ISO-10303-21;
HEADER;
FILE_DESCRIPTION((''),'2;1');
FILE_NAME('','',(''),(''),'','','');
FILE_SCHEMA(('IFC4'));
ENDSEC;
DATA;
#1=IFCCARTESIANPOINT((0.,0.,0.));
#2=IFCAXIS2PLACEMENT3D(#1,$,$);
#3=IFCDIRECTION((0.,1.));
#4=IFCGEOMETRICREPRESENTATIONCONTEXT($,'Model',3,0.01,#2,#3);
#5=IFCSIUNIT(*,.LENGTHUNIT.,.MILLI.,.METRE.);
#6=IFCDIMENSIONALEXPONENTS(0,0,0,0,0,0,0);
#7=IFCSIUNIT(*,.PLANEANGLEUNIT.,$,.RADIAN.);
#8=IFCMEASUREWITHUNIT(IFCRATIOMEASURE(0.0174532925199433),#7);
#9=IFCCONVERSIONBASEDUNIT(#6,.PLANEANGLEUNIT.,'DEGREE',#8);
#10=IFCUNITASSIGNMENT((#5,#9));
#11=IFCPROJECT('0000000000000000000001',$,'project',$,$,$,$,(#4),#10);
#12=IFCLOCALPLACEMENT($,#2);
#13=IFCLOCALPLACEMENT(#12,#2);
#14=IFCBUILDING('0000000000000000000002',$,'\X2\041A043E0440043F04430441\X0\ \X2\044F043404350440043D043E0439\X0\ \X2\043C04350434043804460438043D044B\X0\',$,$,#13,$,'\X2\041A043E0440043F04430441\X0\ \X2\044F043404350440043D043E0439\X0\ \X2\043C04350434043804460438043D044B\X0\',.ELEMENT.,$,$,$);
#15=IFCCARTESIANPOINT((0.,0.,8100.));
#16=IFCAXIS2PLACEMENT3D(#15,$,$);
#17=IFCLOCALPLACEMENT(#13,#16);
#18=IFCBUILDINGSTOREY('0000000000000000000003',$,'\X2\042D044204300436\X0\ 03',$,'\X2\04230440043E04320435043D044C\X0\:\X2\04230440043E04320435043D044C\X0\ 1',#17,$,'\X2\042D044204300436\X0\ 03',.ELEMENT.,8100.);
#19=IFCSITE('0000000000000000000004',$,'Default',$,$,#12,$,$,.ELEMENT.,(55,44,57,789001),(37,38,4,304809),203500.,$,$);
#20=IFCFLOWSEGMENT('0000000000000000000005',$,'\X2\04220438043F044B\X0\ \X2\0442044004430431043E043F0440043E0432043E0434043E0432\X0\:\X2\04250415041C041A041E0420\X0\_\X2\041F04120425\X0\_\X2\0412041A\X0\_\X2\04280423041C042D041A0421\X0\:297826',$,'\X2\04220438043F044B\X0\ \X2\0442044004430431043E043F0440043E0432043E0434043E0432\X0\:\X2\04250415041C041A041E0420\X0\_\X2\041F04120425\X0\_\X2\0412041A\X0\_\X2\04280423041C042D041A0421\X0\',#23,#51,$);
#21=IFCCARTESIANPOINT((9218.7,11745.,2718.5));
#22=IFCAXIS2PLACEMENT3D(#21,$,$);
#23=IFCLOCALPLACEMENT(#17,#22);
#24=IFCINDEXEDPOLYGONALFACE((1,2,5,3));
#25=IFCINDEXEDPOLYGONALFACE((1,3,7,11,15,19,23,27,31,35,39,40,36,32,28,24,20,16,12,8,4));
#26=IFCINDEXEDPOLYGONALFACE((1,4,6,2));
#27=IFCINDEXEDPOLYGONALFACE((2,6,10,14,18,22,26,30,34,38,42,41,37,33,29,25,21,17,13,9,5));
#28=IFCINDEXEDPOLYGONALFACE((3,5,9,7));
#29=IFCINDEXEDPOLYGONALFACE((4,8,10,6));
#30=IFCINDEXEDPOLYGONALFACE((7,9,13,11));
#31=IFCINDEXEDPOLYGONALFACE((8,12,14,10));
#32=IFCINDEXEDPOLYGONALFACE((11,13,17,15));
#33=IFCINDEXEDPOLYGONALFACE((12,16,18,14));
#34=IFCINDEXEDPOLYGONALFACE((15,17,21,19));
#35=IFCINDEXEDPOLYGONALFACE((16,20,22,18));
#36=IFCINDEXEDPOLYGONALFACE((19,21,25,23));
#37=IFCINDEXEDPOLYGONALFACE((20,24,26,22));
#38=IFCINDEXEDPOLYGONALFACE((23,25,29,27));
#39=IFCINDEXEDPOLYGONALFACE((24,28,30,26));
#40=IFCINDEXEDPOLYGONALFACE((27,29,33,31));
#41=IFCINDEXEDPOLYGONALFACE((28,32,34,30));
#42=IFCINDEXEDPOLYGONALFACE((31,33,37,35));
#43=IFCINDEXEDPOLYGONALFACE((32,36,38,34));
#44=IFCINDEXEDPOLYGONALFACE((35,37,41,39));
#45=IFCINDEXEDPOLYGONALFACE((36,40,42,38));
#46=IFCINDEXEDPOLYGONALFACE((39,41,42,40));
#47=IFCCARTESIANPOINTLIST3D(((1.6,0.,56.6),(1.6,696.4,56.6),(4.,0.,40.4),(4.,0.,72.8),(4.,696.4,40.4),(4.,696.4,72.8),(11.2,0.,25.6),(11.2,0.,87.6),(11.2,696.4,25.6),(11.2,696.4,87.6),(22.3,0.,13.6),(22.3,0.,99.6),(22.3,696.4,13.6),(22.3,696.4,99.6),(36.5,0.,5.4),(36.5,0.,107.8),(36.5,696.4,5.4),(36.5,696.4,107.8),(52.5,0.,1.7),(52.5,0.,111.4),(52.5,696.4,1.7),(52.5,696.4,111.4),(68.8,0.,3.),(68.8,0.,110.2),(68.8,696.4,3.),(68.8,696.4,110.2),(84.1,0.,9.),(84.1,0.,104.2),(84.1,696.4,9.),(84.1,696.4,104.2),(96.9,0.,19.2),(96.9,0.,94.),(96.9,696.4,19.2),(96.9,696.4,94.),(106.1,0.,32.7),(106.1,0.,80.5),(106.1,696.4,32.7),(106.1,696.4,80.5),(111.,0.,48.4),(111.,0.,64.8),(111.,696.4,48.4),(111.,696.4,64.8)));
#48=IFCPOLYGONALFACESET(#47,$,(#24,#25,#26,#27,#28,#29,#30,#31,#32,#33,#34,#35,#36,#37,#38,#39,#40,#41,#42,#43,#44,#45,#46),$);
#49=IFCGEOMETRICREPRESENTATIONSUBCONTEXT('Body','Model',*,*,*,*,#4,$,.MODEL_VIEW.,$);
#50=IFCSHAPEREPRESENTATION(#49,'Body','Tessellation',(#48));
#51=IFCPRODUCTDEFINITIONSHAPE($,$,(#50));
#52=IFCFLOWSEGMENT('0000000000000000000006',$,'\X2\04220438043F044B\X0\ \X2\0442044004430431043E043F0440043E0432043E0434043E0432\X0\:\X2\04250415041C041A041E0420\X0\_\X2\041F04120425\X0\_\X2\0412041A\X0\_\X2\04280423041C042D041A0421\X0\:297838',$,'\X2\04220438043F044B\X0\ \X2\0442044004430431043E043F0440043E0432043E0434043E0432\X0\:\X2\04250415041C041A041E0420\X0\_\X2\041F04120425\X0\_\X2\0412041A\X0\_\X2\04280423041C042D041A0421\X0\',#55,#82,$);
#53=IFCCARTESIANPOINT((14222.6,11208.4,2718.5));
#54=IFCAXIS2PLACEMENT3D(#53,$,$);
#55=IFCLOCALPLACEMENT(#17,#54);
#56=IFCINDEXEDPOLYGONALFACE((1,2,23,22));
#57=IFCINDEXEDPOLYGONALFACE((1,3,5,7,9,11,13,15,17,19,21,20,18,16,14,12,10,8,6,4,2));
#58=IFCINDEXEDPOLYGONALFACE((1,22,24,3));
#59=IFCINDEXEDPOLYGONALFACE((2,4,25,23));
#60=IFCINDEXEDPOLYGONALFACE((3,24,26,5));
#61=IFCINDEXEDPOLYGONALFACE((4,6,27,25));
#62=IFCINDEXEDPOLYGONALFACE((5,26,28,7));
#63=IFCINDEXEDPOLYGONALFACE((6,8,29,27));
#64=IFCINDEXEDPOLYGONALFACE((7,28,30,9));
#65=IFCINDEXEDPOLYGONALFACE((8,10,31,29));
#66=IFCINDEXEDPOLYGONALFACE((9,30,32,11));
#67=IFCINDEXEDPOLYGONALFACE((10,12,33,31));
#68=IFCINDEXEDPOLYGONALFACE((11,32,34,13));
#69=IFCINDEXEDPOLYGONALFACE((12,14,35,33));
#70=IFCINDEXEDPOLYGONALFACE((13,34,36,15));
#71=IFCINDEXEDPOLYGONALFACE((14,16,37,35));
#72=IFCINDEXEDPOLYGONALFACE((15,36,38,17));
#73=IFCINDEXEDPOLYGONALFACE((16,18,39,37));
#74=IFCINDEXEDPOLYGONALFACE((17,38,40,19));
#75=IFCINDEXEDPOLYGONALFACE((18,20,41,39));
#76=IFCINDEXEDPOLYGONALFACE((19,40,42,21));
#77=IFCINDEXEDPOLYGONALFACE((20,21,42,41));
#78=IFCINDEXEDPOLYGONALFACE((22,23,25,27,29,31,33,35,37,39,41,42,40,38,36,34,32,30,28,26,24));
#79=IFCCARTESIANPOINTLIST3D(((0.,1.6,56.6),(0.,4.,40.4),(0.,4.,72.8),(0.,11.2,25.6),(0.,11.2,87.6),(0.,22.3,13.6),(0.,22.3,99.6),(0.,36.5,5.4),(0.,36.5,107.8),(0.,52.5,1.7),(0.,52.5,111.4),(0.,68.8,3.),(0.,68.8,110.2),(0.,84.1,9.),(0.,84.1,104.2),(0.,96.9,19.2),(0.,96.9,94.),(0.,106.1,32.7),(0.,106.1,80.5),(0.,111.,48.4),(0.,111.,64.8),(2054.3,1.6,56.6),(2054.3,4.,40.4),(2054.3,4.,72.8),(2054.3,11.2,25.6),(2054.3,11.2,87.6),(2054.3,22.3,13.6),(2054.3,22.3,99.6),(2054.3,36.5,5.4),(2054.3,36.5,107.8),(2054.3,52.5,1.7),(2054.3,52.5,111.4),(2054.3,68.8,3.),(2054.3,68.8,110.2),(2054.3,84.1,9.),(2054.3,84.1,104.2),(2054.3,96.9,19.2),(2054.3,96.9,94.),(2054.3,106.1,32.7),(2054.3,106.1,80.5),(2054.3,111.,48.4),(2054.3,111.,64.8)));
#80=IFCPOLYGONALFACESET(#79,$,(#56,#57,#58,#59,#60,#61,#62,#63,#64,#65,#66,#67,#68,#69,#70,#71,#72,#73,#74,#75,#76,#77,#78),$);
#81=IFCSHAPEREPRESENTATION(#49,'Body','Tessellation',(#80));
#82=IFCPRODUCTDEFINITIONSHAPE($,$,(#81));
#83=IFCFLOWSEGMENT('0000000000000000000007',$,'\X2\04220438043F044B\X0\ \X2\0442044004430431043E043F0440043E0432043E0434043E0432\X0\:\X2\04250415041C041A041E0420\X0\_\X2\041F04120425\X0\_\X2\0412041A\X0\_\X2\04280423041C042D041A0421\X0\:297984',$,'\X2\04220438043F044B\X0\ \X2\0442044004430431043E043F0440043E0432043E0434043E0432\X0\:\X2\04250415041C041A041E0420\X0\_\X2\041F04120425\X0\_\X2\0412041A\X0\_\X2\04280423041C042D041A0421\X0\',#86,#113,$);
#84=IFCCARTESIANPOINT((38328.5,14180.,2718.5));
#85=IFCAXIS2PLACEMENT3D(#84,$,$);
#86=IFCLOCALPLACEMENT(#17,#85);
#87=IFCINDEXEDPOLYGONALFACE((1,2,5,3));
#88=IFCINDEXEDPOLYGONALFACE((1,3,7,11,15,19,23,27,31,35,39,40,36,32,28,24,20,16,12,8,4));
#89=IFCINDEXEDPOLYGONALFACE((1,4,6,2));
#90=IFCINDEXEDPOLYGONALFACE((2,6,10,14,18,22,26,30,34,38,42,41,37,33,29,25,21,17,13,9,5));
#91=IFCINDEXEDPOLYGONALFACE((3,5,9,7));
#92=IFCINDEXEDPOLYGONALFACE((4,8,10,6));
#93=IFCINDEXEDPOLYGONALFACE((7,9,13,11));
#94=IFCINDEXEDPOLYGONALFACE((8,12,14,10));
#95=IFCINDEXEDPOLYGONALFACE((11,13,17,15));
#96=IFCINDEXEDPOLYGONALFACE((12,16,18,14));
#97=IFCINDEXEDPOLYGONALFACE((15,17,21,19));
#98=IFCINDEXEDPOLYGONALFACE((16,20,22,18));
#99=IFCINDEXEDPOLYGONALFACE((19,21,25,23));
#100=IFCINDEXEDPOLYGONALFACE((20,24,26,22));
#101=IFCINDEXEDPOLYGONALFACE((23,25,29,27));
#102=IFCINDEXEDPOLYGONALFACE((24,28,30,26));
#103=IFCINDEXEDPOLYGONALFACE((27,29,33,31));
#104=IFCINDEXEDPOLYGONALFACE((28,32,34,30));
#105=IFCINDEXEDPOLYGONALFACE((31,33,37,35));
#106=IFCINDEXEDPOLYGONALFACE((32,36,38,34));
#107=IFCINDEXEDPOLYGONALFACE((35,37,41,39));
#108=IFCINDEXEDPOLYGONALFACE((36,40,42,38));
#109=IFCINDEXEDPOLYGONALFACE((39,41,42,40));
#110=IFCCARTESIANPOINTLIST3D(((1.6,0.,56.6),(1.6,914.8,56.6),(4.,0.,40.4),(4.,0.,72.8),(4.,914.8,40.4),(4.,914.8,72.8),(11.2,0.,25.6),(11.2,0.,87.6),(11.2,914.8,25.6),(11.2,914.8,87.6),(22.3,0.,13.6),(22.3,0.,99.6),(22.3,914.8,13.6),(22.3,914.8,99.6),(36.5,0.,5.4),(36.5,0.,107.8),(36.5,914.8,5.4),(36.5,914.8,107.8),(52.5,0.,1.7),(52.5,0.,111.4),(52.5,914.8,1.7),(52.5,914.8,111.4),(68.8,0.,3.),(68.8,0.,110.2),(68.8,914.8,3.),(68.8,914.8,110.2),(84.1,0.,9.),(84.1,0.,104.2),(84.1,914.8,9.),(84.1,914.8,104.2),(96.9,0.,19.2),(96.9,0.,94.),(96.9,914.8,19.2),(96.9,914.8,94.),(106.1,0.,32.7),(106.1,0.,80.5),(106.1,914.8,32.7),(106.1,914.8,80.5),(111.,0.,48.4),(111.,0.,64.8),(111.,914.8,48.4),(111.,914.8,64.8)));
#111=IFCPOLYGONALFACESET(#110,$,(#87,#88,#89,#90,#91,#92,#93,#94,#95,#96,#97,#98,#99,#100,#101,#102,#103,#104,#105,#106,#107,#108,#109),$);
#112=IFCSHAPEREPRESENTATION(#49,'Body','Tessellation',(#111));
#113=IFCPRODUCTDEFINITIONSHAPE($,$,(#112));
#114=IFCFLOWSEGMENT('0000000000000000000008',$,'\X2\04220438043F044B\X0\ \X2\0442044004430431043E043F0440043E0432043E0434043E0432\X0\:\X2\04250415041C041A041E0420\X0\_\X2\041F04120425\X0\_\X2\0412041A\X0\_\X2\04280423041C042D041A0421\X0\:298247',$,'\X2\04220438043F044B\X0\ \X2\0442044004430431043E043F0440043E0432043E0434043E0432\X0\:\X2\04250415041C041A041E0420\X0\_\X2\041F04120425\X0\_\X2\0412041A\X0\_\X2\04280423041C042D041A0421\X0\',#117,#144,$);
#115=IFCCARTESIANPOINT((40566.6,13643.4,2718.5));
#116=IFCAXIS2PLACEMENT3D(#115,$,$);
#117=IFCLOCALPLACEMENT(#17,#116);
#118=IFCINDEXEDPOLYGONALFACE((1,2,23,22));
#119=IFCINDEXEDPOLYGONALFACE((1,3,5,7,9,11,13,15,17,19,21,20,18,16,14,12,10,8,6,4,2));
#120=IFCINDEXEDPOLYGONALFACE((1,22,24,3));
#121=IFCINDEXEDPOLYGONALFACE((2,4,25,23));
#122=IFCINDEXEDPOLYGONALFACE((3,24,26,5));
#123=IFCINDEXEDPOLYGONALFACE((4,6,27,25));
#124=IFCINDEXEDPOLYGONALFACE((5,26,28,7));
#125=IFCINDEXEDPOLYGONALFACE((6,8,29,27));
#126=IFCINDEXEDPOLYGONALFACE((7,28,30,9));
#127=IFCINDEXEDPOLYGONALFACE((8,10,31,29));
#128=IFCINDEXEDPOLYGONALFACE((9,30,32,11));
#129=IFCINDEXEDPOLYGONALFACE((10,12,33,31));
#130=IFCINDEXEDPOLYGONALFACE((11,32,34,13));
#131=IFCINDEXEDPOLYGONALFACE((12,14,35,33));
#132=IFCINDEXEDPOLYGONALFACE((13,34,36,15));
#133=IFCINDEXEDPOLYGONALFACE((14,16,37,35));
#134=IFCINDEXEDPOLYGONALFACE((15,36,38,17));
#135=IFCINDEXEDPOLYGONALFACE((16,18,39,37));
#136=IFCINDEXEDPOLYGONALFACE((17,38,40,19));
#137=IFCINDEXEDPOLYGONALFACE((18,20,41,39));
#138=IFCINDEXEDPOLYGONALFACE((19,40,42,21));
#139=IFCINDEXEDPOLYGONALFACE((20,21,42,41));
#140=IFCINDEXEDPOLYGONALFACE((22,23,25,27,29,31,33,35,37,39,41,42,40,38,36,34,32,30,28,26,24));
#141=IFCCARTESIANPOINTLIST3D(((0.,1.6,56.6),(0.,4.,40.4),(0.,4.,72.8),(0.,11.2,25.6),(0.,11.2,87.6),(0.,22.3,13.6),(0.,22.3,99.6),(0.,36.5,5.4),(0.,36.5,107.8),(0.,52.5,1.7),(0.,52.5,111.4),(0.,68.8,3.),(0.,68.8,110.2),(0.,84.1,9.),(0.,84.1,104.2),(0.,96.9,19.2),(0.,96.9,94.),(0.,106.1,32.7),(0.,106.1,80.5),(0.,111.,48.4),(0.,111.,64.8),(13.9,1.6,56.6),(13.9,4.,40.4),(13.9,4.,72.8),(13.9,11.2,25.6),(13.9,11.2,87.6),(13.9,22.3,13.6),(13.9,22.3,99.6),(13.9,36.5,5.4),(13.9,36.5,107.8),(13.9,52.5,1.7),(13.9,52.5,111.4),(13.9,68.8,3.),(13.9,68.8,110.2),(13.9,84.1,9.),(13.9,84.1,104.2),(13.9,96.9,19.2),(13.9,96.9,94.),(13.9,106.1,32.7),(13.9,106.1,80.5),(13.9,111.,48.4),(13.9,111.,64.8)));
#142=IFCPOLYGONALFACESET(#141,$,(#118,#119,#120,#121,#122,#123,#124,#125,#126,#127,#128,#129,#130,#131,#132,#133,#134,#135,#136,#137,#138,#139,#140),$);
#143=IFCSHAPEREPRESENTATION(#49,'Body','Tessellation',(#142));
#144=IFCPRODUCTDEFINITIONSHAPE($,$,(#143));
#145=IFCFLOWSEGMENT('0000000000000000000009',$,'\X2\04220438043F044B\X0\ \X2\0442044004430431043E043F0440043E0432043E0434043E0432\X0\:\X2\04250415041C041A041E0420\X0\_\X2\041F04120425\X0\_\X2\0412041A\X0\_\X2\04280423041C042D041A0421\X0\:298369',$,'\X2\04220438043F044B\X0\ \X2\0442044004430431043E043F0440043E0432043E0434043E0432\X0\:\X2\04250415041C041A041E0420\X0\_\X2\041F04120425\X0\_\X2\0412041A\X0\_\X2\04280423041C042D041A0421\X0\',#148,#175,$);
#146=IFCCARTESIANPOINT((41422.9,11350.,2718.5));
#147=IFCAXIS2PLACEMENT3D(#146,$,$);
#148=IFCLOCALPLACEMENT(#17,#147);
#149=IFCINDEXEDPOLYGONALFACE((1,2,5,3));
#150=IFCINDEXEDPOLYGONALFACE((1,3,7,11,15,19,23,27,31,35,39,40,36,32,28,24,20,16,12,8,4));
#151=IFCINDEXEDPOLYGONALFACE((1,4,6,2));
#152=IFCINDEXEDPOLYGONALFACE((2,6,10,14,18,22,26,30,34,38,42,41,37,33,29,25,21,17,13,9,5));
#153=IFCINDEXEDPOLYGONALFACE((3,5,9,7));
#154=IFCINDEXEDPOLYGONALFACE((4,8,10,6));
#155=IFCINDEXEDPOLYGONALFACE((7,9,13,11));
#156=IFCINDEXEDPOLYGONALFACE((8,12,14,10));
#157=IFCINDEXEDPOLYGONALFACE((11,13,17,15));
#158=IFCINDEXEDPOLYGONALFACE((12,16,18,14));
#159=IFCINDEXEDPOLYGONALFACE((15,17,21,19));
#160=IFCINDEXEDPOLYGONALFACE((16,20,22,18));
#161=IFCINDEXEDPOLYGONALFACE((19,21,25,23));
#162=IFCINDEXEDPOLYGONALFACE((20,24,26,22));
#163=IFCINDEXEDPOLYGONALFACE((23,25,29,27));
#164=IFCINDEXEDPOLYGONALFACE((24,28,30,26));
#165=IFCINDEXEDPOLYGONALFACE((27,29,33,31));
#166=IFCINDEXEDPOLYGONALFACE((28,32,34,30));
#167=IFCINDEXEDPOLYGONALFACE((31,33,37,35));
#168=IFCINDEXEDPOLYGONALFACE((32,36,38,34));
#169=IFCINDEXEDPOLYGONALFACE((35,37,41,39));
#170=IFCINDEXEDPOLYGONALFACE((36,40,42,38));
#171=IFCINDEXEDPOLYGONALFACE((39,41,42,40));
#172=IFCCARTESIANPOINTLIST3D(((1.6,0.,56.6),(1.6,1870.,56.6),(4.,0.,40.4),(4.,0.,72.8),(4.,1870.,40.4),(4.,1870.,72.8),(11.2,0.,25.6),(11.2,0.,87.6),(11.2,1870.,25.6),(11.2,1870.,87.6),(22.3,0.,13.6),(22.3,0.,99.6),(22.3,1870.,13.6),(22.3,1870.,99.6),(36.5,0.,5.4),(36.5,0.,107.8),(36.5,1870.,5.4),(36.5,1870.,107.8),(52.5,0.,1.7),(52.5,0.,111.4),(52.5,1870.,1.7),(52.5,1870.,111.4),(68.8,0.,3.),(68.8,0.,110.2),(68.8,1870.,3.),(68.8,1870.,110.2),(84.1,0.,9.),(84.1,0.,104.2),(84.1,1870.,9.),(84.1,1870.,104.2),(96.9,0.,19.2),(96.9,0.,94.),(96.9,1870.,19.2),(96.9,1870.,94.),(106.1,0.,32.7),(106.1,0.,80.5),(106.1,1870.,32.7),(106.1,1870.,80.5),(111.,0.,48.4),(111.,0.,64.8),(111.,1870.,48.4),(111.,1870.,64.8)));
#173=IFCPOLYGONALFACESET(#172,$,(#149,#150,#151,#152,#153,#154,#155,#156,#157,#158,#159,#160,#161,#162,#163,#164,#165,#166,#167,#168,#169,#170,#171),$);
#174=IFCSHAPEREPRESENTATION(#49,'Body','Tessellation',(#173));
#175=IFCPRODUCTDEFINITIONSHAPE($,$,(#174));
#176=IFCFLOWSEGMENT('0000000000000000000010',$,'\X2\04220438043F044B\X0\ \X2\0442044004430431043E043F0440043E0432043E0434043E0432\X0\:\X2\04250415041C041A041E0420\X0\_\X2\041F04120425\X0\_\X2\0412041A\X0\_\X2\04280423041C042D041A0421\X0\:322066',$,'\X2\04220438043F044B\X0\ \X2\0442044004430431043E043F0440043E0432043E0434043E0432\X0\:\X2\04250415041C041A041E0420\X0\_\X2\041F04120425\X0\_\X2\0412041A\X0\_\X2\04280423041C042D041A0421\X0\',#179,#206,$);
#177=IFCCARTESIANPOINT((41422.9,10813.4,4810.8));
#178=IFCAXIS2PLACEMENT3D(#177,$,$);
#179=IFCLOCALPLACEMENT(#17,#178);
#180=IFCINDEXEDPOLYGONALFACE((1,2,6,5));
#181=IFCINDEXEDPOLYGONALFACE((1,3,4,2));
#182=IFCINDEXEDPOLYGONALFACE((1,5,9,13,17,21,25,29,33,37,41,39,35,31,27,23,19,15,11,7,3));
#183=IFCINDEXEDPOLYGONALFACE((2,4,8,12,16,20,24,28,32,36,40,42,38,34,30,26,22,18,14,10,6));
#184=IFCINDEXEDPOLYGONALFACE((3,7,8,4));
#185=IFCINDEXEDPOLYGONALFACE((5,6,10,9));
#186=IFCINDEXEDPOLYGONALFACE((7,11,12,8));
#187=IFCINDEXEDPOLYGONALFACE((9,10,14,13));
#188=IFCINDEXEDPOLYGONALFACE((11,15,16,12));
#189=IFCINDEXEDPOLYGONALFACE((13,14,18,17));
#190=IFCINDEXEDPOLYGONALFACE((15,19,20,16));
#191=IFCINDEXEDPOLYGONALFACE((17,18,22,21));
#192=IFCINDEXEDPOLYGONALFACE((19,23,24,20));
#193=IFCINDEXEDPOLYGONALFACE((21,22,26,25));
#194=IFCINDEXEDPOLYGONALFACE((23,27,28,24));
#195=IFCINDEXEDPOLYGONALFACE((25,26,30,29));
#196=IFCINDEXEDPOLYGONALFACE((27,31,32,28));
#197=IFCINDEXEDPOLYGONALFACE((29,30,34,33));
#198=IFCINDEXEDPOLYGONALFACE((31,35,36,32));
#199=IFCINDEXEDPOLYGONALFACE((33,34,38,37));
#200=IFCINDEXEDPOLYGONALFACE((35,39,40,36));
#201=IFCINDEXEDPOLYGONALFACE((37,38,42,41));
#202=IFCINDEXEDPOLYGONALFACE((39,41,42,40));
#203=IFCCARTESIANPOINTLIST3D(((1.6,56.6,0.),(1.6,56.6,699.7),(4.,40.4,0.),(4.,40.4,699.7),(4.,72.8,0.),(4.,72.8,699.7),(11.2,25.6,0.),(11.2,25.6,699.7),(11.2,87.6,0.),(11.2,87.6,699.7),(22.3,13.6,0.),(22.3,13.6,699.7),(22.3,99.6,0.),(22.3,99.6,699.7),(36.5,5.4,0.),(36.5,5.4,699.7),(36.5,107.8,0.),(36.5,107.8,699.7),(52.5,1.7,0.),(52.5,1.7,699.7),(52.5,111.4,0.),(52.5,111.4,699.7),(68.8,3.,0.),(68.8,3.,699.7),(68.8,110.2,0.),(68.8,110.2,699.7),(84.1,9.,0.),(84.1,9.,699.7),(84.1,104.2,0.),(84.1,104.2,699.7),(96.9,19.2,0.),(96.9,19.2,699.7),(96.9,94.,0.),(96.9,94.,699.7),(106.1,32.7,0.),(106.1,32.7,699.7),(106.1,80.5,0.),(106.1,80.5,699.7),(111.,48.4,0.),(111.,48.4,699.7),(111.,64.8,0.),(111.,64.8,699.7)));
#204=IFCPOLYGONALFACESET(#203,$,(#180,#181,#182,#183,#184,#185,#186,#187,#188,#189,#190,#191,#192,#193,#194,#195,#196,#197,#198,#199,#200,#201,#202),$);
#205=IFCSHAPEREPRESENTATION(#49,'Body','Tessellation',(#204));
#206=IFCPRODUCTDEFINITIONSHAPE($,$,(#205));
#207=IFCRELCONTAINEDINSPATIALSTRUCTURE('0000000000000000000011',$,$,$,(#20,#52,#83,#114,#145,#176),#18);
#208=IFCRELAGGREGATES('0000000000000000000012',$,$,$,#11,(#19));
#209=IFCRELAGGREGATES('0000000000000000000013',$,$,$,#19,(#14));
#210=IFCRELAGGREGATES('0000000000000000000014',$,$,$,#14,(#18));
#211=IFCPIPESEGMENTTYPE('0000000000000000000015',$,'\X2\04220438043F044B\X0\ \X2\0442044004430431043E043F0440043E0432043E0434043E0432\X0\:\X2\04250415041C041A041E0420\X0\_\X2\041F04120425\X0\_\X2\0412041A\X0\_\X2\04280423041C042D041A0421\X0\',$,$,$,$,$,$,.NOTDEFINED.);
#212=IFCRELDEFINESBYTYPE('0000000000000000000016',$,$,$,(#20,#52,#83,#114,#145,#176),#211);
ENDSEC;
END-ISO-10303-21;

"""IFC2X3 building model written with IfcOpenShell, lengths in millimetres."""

from ifc_helpers import new_model, entity, si_unit, converted_unit, direction, frame, origin, origin_2d_with_axis, place, context, subcontext, project, spatial, circle, extrude, type_object, element, save


model = new_model("IFC2X3")

# Units and contexts
model_context = context("Model", 3, precision=0.01, world=origin(), true_north=direction((0.0, 1.0)))
body_context = subcontext(model_context, "Body", "Model", "MODEL_VIEW")
ifc_project = project(units=[si_unit("LENGTHUNIT", "METRE", prefix="MILLI"), converted_unit("PLANEANGLEUNIT", "DEGREE", entity("IfcRatioMeasure", 0.0174532925199433), si_unit("PLANEANGLEUNIT", "RADIAN"), dimensions=[0, 0, 0, 0, 0, 0, 0])], contexts=[model_context])

# Site, building, storey
site_placement = place(None, frame((0.0, 0.0, 0.0)))
site = spatial("IfcSite", under=ifc_project, at=site_placement, Name="Default", CompositionType="ELEMENT", RefLatitude=(55, 44, 57, 789001), RefLongitude=(37, 38, 4, 304809), RefElevation=203500.0)
building_placement = place(site_placement, origin())
building = spatial("IfcBuilding", under=site, at=building_placement, Name="Корпус ядерной медицины", LongName="Корпус ядерной медицины", CompositionType="ELEMENT")
storey_placement = place(building_placement, frame((0.0, 0.0, 8100.0)))
storey = spatial("IfcBuildingStorey", under=building, at=storey_placement, Name="Этаж 03", ObjectType="Уровень:Уровень 1", LongName="Этаж 03", CompositionType="ELEMENT", Elevation=8100.0)

# Flow segments
pipe_segment_type = type_object("IfcPipeSegmentType", Name="Типы трубопроводов:ХЕМКОР_ПВХ_ВК_ШУМЭКС", PredefinedType="NOTDEFINED")
flow_segment_1_placement = place(storey_placement, frame((9218.7, 11745.0, 2718.5)))
element("IfcFlowSegment", 1, at=flow_segment_1_placement, inside=storey, type_object=pipe_segment_type, Name="Типы трубопроводов:ХЕМКОР_ПВХ_ВК_ШУМЭКС:297826", ObjectType="Типы трубопроводов:ХЕМКОР_ПВХ_ВК_ШУМЭКС", context=body_context, shape_type="SweptSolid", body=[
    extrude(circle(Radius=55.0, at=origin_2d_with_axis()), frame((56.6, 0.0, 56.6), z_axis=(0.0, 1.0, 0.0), x_axis=(-1.0, 0.0, 0.0)), (0.0, 0.0, 1.0), 696.4),
])
flow_segment_2_placement = place(storey_placement, frame((14222.6, 11208.4, 2718.5)))
element("IfcFlowSegment", 2, at=flow_segment_2_placement, inside=storey, type_object=pipe_segment_type, Name="Типы трубопроводов:ХЕМКОР_ПВХ_ВК_ШУМЭКС:297838", ObjectType="Типы трубопроводов:ХЕМКОР_ПВХ_ВК_ШУМЭКС", context=body_context, shape_type="SweptSolid", body=[
    extrude(circle(Radius=55.0, at=origin_2d_with_axis()), frame((0.0, 56.6, 56.6), z_axis=(1.0, 0.0, 0.0), x_axis=(0.0, -1.0, 0.0)), (0.0, 0.0, 1.0), 2054.3),
])
flow_segment_3_placement = place(storey_placement, frame((38328.5, 14180.0, 2718.5)))
element("IfcFlowSegment", 3, at=flow_segment_3_placement, inside=storey, type_object=pipe_segment_type, Name="Типы трубопроводов:ХЕМКОР_ПВХ_ВК_ШУМЭКС:297984", ObjectType="Типы трубопроводов:ХЕМКОР_ПВХ_ВК_ШУМЭКС", context=body_context, shape_type="SweptSolid", body=[
    extrude(circle(Radius=55.0, at=origin_2d_with_axis()), frame((56.6, 0.0, 56.6), z_axis=(0.0, 1.0, 0.0), x_axis=(-1.0, 0.0, 0.0)), (0.0, 0.0, 1.0), 914.8),
])
flow_segment_4_placement = place(storey_placement, frame((40566.6, 13643.4, 2718.5)))
element("IfcFlowSegment", 4, at=flow_segment_4_placement, inside=storey, type_object=pipe_segment_type, Name="Типы трубопроводов:ХЕМКОР_ПВХ_ВК_ШУМЭКС:298247", ObjectType="Типы трубопроводов:ХЕМКОР_ПВХ_ВК_ШУМЭКС", context=body_context, shape_type="SweptSolid", body=[
    extrude(circle(Radius=55.0, at=origin_2d_with_axis()), frame((0.0, 56.6, 56.6), z_axis=(1.0, 0.0, 0.0), x_axis=(0.0, -1.0, 0.0)), (0.0, 0.0, 1.0), 13.9),
])
flow_segment_5_placement = place(storey_placement, frame((41422.9, 11350.0, 2718.5)))
element("IfcFlowSegment", 5, at=flow_segment_5_placement, inside=storey, type_object=pipe_segment_type, Name="Типы трубопроводов:ХЕМКОР_ПВХ_ВК_ШУМЭКС:298369", ObjectType="Типы трубопроводов:ХЕМКОР_ПВХ_ВК_ШУМЭКС", context=body_context, shape_type="SweptSolid", body=[
    extrude(circle(Radius=55.0, at=origin_2d_with_axis()), frame((56.6, 0.0, 56.6), z_axis=(0.0, 1.0, 0.0), x_axis=(-1.0, 0.0, 0.0)), (0.0, 0.0, 1.0), 1870.0),
])
flow_segment_6_placement = place(storey_placement, frame((41422.9, 10813.4, 4810.8)))
element("IfcFlowSegment", 6, at=flow_segment_6_placement, inside=storey, type_object=pipe_segment_type, Name="Типы трубопроводов:ХЕМКОР_ПВХ_ВК_ШУМЭКС:322066", ObjectType="Типы трубопроводов:ХЕМКОР_ПВХ_ВК_ШУМЭКС", context=body_context, shape_type="SweptSolid", body=[
    extrude(circle(Radius=55.0, at=origin_2d_with_axis()), frame((56.6, 56.6, 0.0), z_axis=(0.0, 0.0, 1.0), x_axis=(-1.0, 0.0, 0.0)), (0.0, 0.0, 1.0), 699.7),
])

save(model, "model.ifc")
